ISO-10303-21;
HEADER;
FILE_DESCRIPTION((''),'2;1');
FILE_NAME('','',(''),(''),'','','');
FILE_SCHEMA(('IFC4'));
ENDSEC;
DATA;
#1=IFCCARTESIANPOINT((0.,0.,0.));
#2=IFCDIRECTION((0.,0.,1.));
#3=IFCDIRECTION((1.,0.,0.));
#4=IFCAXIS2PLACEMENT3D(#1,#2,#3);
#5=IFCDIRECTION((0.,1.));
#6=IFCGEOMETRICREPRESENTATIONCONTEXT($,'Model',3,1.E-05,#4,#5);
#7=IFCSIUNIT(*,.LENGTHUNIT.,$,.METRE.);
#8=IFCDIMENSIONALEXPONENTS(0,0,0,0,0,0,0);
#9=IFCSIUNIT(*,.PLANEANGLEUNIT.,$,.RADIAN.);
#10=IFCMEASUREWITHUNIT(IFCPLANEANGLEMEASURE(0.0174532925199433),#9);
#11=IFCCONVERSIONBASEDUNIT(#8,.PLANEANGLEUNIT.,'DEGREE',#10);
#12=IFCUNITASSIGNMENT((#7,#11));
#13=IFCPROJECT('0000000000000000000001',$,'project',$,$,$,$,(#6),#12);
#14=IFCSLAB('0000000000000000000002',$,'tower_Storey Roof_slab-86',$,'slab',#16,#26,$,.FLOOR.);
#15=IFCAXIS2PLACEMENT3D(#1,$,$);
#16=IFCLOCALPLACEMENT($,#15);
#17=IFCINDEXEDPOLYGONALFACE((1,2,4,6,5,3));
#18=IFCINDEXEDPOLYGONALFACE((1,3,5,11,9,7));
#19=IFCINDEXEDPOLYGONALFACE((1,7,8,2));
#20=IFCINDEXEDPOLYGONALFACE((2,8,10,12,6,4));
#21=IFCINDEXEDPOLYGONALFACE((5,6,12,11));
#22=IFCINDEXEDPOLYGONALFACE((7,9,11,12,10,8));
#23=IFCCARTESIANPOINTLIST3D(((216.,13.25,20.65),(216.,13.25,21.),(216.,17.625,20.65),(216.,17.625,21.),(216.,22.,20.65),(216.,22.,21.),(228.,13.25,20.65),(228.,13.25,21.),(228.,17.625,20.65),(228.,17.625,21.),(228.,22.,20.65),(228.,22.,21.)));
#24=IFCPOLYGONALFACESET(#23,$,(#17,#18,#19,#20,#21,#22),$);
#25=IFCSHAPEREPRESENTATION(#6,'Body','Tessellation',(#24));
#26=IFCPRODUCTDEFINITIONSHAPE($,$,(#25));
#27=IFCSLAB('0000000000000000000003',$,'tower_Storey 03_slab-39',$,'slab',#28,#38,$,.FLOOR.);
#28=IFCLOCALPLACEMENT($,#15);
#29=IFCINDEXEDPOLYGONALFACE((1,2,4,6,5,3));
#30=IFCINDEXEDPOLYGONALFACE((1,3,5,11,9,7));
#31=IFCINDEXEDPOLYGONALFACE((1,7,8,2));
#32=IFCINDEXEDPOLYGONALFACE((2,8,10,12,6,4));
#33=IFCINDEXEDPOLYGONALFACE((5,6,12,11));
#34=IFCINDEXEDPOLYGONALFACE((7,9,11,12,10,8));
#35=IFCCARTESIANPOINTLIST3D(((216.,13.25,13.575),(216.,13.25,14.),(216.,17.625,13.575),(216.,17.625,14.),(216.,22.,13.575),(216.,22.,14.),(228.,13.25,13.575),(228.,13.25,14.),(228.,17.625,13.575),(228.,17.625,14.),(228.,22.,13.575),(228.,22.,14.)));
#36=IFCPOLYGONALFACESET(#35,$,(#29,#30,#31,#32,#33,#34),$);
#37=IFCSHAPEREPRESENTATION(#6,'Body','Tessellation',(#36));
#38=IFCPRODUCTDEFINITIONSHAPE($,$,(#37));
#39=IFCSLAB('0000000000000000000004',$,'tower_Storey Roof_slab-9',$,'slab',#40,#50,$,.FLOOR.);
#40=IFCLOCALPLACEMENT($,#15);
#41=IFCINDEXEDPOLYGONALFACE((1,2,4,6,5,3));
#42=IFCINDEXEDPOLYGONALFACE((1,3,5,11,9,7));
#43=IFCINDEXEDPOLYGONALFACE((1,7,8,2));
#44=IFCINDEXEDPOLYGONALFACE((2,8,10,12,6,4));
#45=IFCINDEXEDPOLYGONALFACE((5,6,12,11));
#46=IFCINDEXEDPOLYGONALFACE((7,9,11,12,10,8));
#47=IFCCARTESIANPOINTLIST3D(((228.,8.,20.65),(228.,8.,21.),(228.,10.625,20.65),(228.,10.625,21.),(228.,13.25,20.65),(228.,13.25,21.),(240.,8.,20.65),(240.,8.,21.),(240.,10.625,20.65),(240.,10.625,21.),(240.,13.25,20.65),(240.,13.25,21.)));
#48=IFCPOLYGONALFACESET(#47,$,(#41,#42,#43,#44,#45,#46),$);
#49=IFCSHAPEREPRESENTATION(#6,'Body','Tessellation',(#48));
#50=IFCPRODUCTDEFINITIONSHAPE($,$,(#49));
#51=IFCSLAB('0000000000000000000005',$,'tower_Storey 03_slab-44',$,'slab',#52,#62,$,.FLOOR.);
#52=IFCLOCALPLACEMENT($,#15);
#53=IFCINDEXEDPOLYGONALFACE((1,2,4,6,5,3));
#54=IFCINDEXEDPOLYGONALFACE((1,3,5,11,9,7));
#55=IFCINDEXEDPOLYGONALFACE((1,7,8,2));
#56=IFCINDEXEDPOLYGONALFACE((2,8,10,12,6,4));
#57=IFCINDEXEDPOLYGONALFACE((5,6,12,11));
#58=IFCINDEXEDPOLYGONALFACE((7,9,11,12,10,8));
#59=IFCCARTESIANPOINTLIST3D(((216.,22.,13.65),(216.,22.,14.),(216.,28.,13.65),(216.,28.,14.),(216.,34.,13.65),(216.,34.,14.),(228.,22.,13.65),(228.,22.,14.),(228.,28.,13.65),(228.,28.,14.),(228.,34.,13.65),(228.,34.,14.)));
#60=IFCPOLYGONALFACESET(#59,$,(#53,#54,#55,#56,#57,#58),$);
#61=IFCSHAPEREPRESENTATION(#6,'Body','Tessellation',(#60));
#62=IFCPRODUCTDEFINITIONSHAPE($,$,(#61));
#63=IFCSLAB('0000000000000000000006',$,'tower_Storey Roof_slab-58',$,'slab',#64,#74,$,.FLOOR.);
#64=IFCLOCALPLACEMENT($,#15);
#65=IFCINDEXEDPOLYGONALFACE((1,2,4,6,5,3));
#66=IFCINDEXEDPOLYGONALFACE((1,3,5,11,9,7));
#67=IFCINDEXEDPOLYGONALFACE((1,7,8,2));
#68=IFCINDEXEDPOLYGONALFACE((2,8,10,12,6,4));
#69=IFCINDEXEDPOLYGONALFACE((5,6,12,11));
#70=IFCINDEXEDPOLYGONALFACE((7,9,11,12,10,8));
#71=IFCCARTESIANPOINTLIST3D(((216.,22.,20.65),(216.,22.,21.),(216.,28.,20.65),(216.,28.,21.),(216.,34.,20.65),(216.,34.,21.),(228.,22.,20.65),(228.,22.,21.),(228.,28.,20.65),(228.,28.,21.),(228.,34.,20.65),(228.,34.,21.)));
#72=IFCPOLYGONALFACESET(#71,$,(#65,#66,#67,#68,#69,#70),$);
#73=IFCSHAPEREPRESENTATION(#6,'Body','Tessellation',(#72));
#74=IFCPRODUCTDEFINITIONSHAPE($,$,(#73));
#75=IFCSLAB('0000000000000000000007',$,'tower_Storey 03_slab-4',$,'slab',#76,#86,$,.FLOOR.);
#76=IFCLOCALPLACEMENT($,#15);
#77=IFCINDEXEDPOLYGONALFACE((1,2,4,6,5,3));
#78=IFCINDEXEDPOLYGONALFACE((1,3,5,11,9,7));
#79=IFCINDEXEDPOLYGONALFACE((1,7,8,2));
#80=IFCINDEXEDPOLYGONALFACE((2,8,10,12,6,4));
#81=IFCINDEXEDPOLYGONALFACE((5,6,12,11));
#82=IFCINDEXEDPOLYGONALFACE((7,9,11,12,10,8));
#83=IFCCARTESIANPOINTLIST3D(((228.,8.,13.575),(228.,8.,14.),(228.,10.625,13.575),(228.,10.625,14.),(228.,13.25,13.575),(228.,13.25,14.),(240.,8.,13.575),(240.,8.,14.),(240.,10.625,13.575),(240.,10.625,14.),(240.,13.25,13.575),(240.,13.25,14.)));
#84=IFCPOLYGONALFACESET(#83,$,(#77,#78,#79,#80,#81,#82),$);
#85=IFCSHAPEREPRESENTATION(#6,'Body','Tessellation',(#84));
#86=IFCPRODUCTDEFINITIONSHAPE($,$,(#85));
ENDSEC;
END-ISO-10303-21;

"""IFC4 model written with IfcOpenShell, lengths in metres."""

from ifc_helpers import new_model, entity, si_unit, converted_unit, direction, frame, origin_with_axes, place, context, project, polyline, outline, extrude, element, save


model = new_model("IFC4")

# Units and contexts
model_context = context("Model", 3, precision=1e-05, world=origin_with_axes(), true_north=direction((0.0, 1.0)))
ifc_project = project(units=[si_unit("LENGTHUNIT", "METRE"), converted_unit("PLANEANGLEUNIT", "DEGREE", entity("IfcPlaneAngleMeasure", 0.0174532925199433), si_unit("PLANEANGLEUNIT", "RADIAN"), dimensions=[0, 0, 0, 0, 0, 0, 0])], contexts=[model_context])

# Shared definitions
placement_1 = place(None, origin_with_axes())
placement_2 = place(placement_1, frame((0.0, 0.0, 14.0), z_axis=(0.0, 0.0, 1.0), x_axis=(1.0, 0.0, 0.0)))

# Shared definitions
placement_3 = place(placement_1, frame((0.0, 0.0, 21.0), z_axis=(0.0, 0.0, 1.0), x_axis=(1.0, 0.0, 0.0)))

# Slabs
for number, where, z_axis, x_axis, name in (
    (1, (222.0, 17.625, -0.35), (0.0, 0.0, 1.0), (1.0, 0.0, 0.0), "tower_Storey Roof_slab-86"),
):
    element("IfcSlab", number, at=place(placement_3, frame(where, z_axis=z_axis, x_axis=x_axis)), Name=name, ObjectType="slab", PredefinedType="FLOOR", context=model_context, body=[
        extrude(outline(polyline([(-6.0, 0.0, 0.0), (-6.0, -4.375, 0.0), (6.0, -4.375, 0.0), (6.0, 0.0, 0.0), (6.0, 4.375, 0.0), (-6.0, 4.375, 0.0), (-6.0, 0.0, 0.0)])), origin_with_axes(), (0.0, 0.0, 1.0), 0.35),
    ])
slab_1_placement = place(placement_2, frame((222.0, 17.625, -0.425), z_axis=(0.0, 0.0, 1.0), x_axis=(1.0, 0.0, 0.0)))
element("IfcSlab", 2, at=slab_1_placement, Name="tower_Storey 03_slab-39", ObjectType="slab", PredefinedType="FLOOR", context=model_context, body=[
    extrude(outline(polyline([(-6.0, 0.0, 0.0), (-6.0, -4.375, 0.0), (6.0, -4.375, 0.0), (6.0, 0.0, 0.0), (6.0, 4.375, 0.0), (-6.0, 4.375, 0.0), (-6.0, 0.0, 0.0)])), origin_with_axes(), (0.0, 0.0, 1.0), 0.425),
])
slab_2_placement = place(placement_3, frame((234.0, 10.625, -0.35), z_axis=(0.0, 0.0, 1.0), x_axis=(1.0, 0.0, 0.0)))
element("IfcSlab", 3, at=slab_2_placement, Name="tower_Storey Roof_slab-9", ObjectType="slab", PredefinedType="FLOOR", context=model_context, body=[
    extrude(outline(polyline([(-6.0, -2.625, 0.0), (6.0, -2.625, 0.0), (6.0, 0.0, 0.0), (6.0, 2.625, 0.0), (-6.0, 2.625, 0.0), (-6.0, 0.0, 0.0), (-6.0, -2.625, 0.0)])), origin_with_axes(), (0.0, 0.0, 1.0), 0.35),
])
slab_3_placement = place(placement_2, frame((222.0, 28.0, -0.35), z_axis=(0.0, 0.0, 1.0), x_axis=(1.0, 0.0, 0.0)))
element("IfcSlab", 4, at=slab_3_placement, Name="tower_Storey 03_slab-44", ObjectType="slab", PredefinedType="FLOOR", context=model_context, body=[
    extrude(outline(polyline([(-6.0, -6.0, 0.0), (6.0, -6.0, 0.0), (6.0, 0.0, 0.0), (6.0, 6.0, 0.0), (-6.0, 6.0, 0.0), (-6.0, 0.0, 0.0), (-6.0, -6.0, 0.0)])), origin_with_axes(), (0.0, 0.0, 1.0), 0.35),
])
slab_4_placement = place(placement_3, frame((222.0, 28.0, -0.35), z_axis=(0.0, 0.0, 1.0), x_axis=(1.0, 0.0, 0.0)))
element("IfcSlab", 5, at=slab_4_placement, Name="tower_Storey Roof_slab-58", ObjectType="slab", PredefinedType="FLOOR", context=model_context, body=[
    extrude(outline(polyline([(-6.0, -6.0, 0.0), (6.0, -6.0, 0.0), (6.0, 0.0, 0.0), (6.0, 6.0, 0.0), (-6.0, 6.0, 0.0), (-6.0, 0.0, 0.0), (-6.0, -6.0, 0.0)])), origin_with_axes(), (0.0, 0.0, 1.0), 0.35),
])
slab_5_placement = place(placement_2, frame((234.0, 10.625, -0.425), z_axis=(0.0, 0.0, 1.0), x_axis=(1.0, 0.0, 0.0)))
element("IfcSlab", 6, at=slab_5_placement, Name="tower_Storey 03_slab-4", ObjectType="slab", PredefinedType="FLOOR", context=model_context, body=[
    extrude(outline(polyline([(-6.0, -2.625, 0.0), (6.0, -2.625, 0.0), (6.0, 0.0, 0.0), (6.0, 2.625, 0.0), (-6.0, 2.625, 0.0), (-6.0, 0.0, 0.0), (-6.0, -2.625, 0.0)])), origin_with_axes(), (0.0, 0.0, 1.0), 0.425),
])

save(model, "model.ifc")
